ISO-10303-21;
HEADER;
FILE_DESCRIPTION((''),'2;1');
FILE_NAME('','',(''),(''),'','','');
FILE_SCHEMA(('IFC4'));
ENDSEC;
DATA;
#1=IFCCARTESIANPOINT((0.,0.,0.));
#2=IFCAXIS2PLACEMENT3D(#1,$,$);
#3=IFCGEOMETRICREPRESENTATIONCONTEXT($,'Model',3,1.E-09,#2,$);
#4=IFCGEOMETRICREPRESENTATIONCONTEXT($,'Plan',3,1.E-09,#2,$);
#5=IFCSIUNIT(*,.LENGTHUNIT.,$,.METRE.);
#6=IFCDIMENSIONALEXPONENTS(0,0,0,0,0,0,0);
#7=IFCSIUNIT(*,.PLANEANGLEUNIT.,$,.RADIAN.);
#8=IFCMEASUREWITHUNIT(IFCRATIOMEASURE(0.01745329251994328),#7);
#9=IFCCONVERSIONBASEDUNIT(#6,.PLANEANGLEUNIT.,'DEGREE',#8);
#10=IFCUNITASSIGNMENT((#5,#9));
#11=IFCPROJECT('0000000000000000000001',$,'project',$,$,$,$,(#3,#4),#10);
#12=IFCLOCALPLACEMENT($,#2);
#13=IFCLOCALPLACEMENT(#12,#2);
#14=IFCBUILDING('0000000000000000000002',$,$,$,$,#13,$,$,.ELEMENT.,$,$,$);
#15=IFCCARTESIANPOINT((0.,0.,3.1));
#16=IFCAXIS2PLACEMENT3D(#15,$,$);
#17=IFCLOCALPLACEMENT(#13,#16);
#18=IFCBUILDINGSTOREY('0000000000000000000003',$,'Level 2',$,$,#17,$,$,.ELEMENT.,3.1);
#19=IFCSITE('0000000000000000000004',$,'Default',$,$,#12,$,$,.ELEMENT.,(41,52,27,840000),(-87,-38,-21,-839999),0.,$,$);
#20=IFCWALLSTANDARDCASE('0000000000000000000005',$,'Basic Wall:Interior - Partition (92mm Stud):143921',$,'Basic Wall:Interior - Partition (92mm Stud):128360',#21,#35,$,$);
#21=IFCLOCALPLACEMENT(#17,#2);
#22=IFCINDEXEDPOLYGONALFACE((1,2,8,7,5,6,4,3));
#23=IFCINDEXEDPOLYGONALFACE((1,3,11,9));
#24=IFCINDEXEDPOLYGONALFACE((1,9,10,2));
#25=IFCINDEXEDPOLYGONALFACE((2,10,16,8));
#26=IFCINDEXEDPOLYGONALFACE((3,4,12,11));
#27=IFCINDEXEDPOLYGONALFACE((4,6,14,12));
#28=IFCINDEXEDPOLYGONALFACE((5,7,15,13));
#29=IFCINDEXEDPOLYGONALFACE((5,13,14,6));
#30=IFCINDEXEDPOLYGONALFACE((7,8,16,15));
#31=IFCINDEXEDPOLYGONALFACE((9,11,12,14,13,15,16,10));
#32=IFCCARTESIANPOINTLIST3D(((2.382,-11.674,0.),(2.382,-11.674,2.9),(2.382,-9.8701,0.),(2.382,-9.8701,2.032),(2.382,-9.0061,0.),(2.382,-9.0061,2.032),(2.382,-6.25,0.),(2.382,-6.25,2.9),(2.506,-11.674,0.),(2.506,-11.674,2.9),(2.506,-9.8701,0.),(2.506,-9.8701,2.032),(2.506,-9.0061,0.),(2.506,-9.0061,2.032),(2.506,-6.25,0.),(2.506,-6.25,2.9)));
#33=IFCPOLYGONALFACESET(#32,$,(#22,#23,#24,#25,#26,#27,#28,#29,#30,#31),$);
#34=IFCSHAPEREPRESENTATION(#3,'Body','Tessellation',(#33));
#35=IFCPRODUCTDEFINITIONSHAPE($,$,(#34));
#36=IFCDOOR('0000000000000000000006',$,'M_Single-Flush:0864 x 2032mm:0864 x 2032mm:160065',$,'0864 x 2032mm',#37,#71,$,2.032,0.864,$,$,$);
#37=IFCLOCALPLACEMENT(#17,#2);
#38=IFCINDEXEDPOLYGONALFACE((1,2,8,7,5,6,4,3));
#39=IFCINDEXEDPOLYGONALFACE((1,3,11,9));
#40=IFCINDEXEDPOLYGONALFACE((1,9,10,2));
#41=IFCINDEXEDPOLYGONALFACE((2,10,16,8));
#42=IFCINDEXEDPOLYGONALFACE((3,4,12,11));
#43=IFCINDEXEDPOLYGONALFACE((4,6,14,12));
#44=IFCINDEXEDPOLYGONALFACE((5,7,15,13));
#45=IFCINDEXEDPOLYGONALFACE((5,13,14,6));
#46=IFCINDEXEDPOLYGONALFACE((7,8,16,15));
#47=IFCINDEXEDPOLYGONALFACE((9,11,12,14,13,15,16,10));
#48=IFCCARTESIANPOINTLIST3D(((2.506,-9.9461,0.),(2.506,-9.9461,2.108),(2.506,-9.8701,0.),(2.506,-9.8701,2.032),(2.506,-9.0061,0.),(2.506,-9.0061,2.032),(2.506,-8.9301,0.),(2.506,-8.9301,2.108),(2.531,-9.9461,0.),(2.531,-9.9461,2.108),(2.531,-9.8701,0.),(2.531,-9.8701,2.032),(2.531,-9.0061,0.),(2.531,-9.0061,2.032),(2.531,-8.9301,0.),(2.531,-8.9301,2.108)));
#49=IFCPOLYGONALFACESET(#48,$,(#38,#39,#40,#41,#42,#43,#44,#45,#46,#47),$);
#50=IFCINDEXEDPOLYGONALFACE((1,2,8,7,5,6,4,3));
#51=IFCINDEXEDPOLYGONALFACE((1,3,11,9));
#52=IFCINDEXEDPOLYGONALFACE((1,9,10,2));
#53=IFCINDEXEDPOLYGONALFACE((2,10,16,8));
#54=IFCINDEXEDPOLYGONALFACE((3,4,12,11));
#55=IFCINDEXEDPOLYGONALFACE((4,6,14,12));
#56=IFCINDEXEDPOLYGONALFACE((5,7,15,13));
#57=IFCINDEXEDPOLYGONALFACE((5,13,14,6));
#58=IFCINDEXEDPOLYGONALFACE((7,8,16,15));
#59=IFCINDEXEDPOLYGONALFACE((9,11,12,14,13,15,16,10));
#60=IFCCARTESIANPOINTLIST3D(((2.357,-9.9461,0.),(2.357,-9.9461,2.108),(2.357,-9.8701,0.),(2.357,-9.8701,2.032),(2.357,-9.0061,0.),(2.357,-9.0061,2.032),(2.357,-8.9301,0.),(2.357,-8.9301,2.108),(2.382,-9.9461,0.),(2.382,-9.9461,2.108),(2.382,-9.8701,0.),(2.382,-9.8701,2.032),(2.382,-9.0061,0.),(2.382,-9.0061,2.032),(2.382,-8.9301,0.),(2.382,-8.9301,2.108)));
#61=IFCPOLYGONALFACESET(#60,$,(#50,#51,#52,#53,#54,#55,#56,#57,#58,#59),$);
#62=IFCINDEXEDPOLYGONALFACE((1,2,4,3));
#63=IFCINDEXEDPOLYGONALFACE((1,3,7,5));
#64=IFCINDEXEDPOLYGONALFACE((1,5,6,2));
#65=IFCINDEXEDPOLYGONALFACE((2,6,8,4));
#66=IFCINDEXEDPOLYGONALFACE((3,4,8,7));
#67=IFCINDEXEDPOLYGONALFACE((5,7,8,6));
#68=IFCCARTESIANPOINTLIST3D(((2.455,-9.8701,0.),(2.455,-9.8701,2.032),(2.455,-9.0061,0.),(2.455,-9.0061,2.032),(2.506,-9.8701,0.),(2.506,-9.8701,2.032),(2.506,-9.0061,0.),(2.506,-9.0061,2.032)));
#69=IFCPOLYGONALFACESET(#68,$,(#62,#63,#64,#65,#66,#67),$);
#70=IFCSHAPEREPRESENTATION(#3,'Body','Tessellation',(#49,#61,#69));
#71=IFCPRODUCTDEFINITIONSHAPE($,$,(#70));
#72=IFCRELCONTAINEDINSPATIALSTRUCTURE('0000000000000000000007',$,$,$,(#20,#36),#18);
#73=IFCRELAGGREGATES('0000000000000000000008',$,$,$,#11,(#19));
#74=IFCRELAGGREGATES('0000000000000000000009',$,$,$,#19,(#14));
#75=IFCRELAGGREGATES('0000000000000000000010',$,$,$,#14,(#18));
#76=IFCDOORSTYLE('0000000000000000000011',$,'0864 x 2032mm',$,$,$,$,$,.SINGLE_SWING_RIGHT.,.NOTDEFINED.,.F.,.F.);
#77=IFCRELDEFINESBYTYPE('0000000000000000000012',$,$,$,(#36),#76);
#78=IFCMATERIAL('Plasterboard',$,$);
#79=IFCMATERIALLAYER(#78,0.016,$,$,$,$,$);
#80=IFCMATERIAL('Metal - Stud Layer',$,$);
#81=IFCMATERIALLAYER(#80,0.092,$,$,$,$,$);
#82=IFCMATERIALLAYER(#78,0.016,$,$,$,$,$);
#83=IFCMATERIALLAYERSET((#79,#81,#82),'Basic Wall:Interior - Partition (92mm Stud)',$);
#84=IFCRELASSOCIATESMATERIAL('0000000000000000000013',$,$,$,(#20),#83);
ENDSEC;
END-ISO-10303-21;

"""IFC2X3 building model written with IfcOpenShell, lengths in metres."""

from ifc_helpers import new_model, entity, si_unit, converted_unit, frame, frame_2d, origin, origin_2d_with_axis, place, context, project, spatial, polyline, rectangle, outline, extrude, source, transform, mapped, material, layer, layer_set, layer_usage, type_object, type_shapes, element, fill, save


model = new_model("IFC2X3")

# Units and contexts
model_context = context("Model", 3, precision=1e-09, world=origin())
plan_context = context("Plan", 3, precision=1e-09, world=origin())
ifc_project = project(units=[si_unit("LENGTHUNIT", "METRE"), converted_unit("PLANEANGLEUNIT", "DEGREE", entity("IfcRatioMeasure", 0.01745329251994328), si_unit("PLANEANGLEUNIT", "RADIAN"), dimensions=[0, 0, 0, 0, 0, 0, 0])], contexts=[model_context, plan_context])

# Site, building, storey
site_placement = place(None, origin())
site = spatial("IfcSite", under=ifc_project, at=site_placement, Name="Default", CompositionType="ELEMENT", RefLatitude=(41, 52, 27, 840000), RefLongitude=(-87, -38, -21, -839999), RefElevation=0.0)
building_placement = place(site_placement, origin())
building = spatial("IfcBuilding", under=site, at=building_placement, CompositionType="ELEMENT")
storey_placement = place(building_placement, frame((0.0, 0.0, 3.1)))
storey = spatial("IfcBuildingStorey", under=building, at=storey_placement, Name="Level 2", CompositionType="ELEMENT", Elevation=3.1)

# Wall, opening, door
ifc_material_1 = material(Name="Plasterboard")
ifc_layer_1 = layer(ifc_material_1, 0.016)
ifc_material_2 = material(Name="Metal - Stud Layer")
ifc_layer_2 = layer(ifc_material_2, 0.092)
ifc_layer_3 = layer(ifc_material_1, 0.016)
ifc_layer_set = layer_set([ifc_layer_1, ifc_layer_2, ifc_layer_3], Name="Basic Wall:Interior - Partition (92mm Stud)")
ifc_layer_usage = layer_usage(ifc_layer_set, "AXIS2", "NEGATIVE", 0.062)
wall_placement = place(storey_placement, frame((2.444, -6.25, 0.0), z_axis=(0.0, 0.0, 1.0), x_axis=(0.0, -1.0, 0.0)))
wall = element("IfcWallStandardCase", 1, at=wall_placement, inside=storey, material=ifc_layer_usage, Name="Basic Wall:Interior - Partition (92mm Stud):143921", ObjectType="Basic Wall:Interior - Partition (92mm Stud):128360", context=model_context, shape_type="SweptSolid", body=[
    extrude(rectangle(XDim=5.424, YDim=0.124, at=frame_2d((2.712, 0.0), x_axis=(-1.0, 0.0))), origin(), (0.0, 0.0, 1.0), 2.9),
])
opening_placement = place(wall_placement, frame((2.7561, -0.062, 0.0)))
opening = element("IfcOpeningElement", 2, at=opening_placement, cuts=wall, ObjectType="Opening", context=model_context, shape_type="SweptSolid", body=[
    extrude(rectangle(XDim=0.864, YDim=2.032, at=frame_2d((1.016, 0.432), x_axis=(0.0, 1.0))), frame((0.0, 0.0, 0.0), z_axis=(0.0, 1.0, 0.0), x_axis=(0.0, 0.0, 1.0)), (0.0, 0.0, 1.0), 0.124),
])
door_style = type_object("IfcDoorStyle", Name="0864 x 2032mm", ConstructionType="NOTDEFINED", OperationType="SINGLE_SWING_RIGHT", ParameterTakesPrecedence=False, Sizeable=False)
shared_shape = source(origin(), model_context, "Body", "SweptSolid", [
    extrude(outline(polyline([(-0.508, -1.073), (0.508, -1.073), (0.508, 1.035), (0.432, 1.035), (0.432, -0.997), (-0.432, -0.997), (-0.432, 1.035), (-0.508, 1.035), (-0.508, -1.073)])), frame((0.432, 0.124, 1.035), z_axis=(0.0, 1.0, 0.0), x_axis=(1.0, 0.0, 0.0)), (0.0, 0.0, 1.0), 0.025),
    extrude(outline(polyline([(-1.073, -0.508), (1.035, -0.508), (1.035, -0.432), (-0.997, -0.432), (-0.997, 0.432), (1.035, 0.432), (1.035, 0.508), (-1.073, 0.508), (-1.073, -0.508)])), frame((0.432, -0.025, 1.035), z_axis=(0.0, 1.0, 0.0), x_axis=(0.0, 0.0, -1.0)), (0.0, 0.0, 1.0), 0.025),
    extrude(rectangle(XDim=0.051, YDim=0.864, at=origin_2d_with_axis()), frame((0.432, 0.0985, 0.0), z_axis=(0.0, 0.0, 1.0), x_axis=(0.0, 1.0, 0.0)), (0.0, 0.0, 1.0), 2.032),
])
type_shapes(door_style, [shared_shape])
door_placement = place(opening_placement, origin())
door = element("IfcDoor", 3, at=door_placement, inside=storey, type_object=door_style, Name="M_Single-Flush:0864 x 2032mm:0864 x 2032mm:160065", ObjectType="0864 x 2032mm", OverallHeight=2.032, OverallWidth=0.864, context=model_context, shape_type="MappedRepresentation", body=[
    mapped(shared_shape, transform((0.0, 0.0, 0.0), scale=1.0)),
])
fill(opening, door)

save(model, "model.ifc")
